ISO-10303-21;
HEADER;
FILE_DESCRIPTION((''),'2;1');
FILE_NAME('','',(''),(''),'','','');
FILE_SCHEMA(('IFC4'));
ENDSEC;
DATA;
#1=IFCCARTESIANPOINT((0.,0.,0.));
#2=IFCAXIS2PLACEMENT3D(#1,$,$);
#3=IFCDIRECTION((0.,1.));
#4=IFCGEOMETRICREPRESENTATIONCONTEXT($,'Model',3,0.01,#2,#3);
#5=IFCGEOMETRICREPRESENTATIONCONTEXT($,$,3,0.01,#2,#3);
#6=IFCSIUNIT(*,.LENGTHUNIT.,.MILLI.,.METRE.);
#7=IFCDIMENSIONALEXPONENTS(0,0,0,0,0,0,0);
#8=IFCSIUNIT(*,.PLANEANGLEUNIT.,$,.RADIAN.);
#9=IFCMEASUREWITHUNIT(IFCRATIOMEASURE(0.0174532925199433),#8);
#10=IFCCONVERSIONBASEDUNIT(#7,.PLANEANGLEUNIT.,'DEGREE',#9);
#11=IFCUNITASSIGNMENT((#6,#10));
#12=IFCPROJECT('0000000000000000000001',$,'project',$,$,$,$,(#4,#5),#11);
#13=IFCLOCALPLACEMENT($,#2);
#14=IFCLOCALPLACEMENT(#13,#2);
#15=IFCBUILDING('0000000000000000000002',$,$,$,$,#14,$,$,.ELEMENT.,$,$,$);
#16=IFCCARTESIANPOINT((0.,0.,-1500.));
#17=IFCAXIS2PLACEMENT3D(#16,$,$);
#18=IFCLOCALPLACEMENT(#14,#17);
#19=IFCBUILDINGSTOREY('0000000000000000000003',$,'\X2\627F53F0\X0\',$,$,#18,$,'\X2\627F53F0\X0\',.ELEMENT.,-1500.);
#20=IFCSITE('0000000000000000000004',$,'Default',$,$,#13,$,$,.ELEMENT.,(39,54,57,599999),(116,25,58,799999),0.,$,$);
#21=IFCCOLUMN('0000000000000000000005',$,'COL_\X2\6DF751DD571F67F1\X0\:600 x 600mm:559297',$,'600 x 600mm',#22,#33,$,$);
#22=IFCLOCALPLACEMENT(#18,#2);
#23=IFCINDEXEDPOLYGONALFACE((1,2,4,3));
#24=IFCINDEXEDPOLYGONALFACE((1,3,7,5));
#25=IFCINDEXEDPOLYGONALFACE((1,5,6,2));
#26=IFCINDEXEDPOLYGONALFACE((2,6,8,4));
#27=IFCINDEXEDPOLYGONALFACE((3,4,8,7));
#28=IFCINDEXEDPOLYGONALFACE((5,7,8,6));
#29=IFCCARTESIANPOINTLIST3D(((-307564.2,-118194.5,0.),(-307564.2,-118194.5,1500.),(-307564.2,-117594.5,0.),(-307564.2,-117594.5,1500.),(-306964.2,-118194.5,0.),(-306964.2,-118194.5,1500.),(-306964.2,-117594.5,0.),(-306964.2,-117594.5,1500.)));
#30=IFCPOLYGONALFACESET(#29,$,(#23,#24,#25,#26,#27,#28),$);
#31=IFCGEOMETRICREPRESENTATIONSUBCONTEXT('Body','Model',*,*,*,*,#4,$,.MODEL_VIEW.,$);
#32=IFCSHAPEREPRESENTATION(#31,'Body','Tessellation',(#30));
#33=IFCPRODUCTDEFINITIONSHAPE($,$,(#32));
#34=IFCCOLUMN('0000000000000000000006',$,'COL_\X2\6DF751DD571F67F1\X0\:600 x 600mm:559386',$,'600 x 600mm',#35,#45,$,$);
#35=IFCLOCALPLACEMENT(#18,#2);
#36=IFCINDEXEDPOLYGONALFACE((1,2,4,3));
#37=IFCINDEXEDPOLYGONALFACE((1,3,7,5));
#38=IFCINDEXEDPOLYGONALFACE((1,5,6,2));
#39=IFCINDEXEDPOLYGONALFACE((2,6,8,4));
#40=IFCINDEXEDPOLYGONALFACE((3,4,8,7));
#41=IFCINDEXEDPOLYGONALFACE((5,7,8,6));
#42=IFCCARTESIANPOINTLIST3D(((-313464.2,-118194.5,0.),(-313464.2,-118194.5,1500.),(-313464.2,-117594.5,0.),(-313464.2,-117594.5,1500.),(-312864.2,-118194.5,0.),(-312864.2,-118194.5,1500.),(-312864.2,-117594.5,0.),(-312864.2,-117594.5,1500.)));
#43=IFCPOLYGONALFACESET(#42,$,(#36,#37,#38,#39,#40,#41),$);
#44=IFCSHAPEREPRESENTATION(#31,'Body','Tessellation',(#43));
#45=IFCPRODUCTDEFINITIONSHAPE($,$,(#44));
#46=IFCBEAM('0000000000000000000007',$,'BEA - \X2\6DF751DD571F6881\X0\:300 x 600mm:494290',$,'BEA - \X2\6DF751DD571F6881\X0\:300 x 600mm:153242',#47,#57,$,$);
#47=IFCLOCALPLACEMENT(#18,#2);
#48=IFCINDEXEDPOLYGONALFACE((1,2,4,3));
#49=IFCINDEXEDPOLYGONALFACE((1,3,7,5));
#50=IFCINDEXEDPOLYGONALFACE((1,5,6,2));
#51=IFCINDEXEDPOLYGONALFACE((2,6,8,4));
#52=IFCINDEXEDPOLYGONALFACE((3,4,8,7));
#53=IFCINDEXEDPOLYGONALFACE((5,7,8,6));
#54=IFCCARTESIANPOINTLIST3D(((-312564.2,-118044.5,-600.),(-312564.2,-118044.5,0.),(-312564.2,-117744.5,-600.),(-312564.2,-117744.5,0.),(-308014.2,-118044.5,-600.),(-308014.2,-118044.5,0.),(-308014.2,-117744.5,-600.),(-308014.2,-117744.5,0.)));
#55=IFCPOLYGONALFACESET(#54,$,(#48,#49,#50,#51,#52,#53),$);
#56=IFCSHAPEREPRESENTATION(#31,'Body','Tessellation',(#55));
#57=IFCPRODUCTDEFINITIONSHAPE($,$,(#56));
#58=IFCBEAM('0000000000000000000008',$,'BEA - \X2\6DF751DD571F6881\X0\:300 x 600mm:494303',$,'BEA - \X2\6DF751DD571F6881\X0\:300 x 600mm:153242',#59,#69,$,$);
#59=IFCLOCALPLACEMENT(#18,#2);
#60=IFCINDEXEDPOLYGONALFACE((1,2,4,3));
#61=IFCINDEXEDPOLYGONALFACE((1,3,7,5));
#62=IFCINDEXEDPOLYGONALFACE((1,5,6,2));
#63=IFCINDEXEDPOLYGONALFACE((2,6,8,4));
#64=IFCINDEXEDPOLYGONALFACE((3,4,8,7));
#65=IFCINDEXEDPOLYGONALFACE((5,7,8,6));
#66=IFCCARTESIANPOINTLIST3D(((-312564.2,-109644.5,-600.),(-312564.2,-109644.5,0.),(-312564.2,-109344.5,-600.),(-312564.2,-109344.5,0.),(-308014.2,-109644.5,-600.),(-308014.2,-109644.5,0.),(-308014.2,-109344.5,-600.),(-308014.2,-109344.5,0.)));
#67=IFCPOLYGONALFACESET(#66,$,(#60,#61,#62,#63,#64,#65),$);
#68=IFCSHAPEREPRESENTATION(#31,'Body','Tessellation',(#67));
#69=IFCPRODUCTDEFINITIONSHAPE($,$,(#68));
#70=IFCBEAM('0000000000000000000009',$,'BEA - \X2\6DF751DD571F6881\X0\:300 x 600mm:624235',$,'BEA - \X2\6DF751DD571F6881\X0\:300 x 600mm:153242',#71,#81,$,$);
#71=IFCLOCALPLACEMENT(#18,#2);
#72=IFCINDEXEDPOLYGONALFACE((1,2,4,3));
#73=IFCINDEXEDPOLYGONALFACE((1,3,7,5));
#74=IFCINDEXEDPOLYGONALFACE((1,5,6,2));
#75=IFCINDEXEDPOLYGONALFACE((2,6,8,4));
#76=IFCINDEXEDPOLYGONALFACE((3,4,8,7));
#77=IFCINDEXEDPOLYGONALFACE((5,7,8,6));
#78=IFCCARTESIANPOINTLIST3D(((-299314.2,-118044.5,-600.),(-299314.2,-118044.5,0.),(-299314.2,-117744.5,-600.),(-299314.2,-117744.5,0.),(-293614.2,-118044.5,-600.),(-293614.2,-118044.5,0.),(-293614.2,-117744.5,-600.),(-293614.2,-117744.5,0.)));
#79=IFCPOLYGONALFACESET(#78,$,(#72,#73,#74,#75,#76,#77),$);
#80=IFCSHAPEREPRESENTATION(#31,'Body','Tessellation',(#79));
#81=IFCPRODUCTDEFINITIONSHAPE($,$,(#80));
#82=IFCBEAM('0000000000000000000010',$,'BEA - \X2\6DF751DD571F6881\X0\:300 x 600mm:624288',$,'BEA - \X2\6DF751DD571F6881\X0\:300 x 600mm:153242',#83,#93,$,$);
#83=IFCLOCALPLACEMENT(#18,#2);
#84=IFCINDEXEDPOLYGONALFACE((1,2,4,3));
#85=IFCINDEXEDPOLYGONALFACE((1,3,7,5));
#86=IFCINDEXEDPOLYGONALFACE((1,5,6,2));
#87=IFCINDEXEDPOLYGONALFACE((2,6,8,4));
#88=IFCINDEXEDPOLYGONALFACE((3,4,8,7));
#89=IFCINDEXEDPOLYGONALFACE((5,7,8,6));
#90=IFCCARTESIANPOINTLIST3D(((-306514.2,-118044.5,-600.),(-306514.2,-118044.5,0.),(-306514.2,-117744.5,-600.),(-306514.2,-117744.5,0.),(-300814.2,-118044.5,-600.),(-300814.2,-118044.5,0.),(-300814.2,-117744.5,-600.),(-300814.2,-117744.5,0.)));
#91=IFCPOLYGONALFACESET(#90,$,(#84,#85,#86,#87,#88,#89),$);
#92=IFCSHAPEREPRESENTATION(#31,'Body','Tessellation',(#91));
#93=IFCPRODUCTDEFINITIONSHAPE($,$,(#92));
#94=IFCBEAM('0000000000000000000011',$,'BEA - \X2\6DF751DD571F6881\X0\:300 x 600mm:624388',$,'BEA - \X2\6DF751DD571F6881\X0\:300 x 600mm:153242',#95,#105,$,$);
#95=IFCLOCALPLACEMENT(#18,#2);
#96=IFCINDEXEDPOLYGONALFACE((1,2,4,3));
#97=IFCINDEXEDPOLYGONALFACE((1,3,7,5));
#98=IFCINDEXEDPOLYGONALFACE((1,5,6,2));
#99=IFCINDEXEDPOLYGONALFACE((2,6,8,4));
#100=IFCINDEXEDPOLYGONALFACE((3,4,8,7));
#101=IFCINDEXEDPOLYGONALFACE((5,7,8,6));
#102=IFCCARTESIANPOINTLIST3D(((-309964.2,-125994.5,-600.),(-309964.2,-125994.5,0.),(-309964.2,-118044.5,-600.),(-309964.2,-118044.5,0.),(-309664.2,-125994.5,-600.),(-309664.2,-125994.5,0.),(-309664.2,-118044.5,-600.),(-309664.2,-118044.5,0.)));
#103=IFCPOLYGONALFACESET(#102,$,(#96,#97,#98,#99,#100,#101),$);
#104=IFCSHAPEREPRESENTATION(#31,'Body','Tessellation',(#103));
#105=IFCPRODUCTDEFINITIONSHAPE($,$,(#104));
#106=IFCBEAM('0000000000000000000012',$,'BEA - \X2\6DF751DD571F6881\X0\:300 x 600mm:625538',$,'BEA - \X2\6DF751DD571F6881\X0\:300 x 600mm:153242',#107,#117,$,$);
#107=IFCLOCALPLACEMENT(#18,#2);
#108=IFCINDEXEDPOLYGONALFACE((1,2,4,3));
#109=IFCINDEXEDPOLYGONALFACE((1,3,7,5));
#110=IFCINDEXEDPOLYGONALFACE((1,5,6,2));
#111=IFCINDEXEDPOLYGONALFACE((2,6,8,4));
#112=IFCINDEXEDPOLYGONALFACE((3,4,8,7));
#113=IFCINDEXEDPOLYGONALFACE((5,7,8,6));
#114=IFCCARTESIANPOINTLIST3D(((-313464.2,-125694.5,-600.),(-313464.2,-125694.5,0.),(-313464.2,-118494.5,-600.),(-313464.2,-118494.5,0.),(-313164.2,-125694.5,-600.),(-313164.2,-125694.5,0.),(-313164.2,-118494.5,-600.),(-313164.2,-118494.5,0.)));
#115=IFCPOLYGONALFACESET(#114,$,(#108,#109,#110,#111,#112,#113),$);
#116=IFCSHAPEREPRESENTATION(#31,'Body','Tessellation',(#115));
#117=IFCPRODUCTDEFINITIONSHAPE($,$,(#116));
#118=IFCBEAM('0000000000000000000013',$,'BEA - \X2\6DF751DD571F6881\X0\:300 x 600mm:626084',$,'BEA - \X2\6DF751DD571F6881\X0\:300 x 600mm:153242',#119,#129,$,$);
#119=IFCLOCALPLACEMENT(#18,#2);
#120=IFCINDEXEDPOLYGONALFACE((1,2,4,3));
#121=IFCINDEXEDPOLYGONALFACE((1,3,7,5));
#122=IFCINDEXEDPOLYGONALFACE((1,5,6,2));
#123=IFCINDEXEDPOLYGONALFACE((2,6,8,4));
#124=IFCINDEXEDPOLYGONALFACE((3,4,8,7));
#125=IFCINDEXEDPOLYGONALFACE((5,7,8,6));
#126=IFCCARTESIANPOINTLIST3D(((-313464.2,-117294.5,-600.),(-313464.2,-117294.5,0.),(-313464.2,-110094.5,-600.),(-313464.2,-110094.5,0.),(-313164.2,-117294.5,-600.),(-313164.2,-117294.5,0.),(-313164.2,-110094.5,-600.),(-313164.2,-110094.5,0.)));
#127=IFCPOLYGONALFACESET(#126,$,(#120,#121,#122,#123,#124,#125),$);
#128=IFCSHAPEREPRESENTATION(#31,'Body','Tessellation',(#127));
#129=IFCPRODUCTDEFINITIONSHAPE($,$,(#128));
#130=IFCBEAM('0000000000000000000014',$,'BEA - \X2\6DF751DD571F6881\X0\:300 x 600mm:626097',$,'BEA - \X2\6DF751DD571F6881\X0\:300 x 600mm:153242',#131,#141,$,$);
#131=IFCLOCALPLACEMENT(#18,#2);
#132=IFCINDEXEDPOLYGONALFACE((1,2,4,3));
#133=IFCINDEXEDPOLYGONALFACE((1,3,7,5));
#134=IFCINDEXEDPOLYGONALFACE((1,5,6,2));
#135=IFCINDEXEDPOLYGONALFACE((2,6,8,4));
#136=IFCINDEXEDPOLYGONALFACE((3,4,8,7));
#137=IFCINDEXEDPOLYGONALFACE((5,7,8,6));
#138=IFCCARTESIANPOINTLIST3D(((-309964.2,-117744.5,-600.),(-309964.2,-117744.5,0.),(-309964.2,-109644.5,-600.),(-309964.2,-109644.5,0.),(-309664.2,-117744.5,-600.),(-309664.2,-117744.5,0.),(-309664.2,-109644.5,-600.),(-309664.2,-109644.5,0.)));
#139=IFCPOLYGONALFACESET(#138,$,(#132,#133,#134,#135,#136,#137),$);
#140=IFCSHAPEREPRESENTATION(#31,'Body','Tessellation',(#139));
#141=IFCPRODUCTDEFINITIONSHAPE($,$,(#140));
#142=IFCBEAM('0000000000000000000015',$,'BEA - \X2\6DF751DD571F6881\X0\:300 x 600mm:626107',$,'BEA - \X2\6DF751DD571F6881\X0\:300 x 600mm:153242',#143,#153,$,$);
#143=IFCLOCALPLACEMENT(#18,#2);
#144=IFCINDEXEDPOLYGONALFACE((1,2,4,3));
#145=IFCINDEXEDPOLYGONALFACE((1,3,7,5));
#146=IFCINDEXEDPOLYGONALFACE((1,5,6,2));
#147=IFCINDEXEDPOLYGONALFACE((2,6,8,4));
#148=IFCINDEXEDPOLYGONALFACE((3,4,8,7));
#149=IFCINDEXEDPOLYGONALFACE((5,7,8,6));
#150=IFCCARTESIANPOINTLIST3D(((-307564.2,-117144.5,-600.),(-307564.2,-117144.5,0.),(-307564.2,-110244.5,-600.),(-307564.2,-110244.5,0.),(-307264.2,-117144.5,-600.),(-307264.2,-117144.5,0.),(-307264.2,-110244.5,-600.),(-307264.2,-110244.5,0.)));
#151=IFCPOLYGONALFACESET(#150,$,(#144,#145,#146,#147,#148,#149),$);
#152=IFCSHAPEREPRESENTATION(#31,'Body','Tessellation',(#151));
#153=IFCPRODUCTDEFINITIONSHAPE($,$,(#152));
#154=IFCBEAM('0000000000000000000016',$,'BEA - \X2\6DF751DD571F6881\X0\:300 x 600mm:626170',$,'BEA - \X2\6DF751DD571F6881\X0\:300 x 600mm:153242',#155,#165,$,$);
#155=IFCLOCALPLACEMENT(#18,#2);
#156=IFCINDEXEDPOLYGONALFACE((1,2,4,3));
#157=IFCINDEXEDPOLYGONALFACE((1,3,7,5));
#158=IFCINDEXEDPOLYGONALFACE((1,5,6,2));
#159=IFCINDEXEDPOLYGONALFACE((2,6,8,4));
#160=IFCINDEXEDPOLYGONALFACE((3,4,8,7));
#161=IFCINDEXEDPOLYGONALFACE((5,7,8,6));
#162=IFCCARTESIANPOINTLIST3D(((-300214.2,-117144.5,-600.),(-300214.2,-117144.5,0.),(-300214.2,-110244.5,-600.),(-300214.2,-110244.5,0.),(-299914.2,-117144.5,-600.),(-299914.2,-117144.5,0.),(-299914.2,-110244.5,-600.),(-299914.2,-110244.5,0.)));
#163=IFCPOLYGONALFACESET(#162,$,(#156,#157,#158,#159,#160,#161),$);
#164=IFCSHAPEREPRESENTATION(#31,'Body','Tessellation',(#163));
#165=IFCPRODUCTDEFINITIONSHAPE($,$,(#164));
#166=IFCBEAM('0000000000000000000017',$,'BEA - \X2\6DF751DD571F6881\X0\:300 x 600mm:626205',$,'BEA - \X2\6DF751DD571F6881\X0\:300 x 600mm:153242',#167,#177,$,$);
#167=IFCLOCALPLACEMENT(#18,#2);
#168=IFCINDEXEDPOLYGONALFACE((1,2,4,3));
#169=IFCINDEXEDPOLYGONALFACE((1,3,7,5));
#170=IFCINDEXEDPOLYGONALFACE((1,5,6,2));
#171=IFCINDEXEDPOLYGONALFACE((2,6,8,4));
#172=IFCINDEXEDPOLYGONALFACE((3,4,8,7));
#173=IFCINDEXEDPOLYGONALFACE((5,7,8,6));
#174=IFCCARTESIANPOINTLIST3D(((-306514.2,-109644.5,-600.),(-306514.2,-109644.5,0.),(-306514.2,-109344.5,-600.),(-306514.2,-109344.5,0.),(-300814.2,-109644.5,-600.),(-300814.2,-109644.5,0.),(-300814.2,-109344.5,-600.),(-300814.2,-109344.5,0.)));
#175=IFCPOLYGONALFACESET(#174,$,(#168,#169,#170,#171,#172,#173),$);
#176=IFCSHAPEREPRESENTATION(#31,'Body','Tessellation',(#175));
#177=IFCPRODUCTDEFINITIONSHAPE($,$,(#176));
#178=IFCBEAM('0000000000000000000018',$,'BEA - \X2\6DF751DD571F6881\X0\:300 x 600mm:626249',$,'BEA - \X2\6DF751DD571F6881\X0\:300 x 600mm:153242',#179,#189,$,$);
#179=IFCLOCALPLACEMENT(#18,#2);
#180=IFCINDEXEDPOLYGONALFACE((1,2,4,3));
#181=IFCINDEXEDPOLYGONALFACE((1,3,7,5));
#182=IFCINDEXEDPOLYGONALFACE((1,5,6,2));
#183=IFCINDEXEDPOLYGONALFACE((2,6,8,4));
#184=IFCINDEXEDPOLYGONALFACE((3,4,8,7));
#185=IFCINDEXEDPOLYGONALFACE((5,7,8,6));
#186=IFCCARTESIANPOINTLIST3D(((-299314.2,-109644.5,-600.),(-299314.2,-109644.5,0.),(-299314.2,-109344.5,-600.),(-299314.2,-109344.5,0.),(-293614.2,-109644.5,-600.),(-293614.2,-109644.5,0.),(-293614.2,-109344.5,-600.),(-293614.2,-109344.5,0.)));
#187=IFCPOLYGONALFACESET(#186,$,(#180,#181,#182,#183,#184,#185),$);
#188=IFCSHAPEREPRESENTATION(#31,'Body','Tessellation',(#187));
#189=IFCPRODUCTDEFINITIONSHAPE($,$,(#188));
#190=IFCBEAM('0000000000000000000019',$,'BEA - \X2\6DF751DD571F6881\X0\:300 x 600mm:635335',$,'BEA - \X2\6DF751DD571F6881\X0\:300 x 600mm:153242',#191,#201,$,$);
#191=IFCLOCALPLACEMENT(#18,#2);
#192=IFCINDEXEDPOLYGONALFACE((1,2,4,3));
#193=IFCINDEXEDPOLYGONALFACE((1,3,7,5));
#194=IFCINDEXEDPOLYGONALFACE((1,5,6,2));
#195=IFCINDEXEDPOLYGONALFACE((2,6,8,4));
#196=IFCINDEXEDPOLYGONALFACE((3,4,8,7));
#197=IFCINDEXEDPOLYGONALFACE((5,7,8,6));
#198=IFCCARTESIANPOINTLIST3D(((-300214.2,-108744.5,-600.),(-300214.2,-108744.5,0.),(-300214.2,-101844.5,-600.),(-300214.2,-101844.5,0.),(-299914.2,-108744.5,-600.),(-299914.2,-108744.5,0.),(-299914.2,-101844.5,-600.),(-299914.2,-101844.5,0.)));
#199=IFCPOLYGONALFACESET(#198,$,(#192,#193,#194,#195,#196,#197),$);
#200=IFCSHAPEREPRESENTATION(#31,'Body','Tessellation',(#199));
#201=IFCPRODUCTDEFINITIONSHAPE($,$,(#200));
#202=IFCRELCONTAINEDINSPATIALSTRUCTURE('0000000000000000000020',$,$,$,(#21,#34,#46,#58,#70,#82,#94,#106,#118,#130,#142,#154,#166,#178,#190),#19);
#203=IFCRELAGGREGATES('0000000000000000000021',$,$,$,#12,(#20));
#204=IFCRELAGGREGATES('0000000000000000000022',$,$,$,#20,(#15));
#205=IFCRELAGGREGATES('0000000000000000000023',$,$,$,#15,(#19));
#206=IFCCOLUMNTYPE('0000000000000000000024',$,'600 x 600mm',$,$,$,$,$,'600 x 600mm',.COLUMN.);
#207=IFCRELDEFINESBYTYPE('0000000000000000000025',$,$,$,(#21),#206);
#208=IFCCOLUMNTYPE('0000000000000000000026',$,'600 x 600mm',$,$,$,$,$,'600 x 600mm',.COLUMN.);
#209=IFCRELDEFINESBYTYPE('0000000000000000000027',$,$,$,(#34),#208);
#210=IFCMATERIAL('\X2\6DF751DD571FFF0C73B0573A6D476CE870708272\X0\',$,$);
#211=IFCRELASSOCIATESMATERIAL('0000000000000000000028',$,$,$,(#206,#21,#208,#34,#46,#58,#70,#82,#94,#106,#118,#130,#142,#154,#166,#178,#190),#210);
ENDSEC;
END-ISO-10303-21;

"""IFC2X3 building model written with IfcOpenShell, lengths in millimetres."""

from ifc_helpers import new_model, entity, si_unit, converted_unit, direction, frame, frame_2d, origin, origin_2d_with_axis, place, context, subcontext, project, spatial, rectangle, extrude, source, transform, mapped, material, type_object, type_shapes, element, save


model = new_model("IFC2X3")

# Units and contexts
model_context = context("Model", 3, precision=0.01, world=origin(), true_north=direction((0.0, 1.0)))
context_of_model = context(None, 3, precision=0.01, world=origin(), true_north=direction((0.0, 1.0)))
body_context = subcontext(model_context, "Body", "Model", "MODEL_VIEW")
ifc_project = project(units=[si_unit("LENGTHUNIT", "METRE", prefix="MILLI"), converted_unit("PLANEANGLEUNIT", "DEGREE", entity("IfcRatioMeasure", 0.0174532925199433), si_unit("PLANEANGLEUNIT", "RADIAN"), dimensions=[0, 0, 0, 0, 0, 0, 0])], contexts=[model_context, context_of_model])

# Site, building, storey
site_placement = place(None, origin())
site = spatial("IfcSite", under=ifc_project, at=site_placement, Name="Default", CompositionType="ELEMENT", RefLatitude=(39, 54, 57, 599999), RefLongitude=(116, 25, 58, 799999), RefElevation=0.0)
building_placement = place(site_placement, origin())
building = spatial("IfcBuilding", under=site, at=building_placement, CompositionType="ELEMENT")
storey_placement = place(building_placement, frame((0.0, 0.0, -1500.0)))
storey = spatial("IfcBuildingStorey", under=building, at=storey_placement, Name="承台", LongName="承台", CompositionType="ELEMENT", Elevation=-1500.0)

# Columns
ifc_material_1 = material(Name="混凝土，现场浇注灰色")
column_type_1 = type_object("IfcColumnType", Name="600 x 600mm", ElementType="600 x 600mm", PredefinedType="COLUMN", material=ifc_material_1)
shared_shape_1 = source(origin(), body_context, "Body", "SweptSolid", [
    extrude(rectangle(XDim=600.0, YDim=600.0, at=origin_2d_with_axis()), frame((300.0, 300.0, 0.0), z_axis=(0.0, 0.0, 1.0), x_axis=(-1.0, 0.0, 0.0)), (0.0, 0.0, 1.0), 1500.0),
])
type_shapes(column_type_1, [shared_shape_1])
column_1_placement = place(storey_placement, frame((-307564.2, -118194.5, 0.0)))
element("IfcColumn", 1, at=column_1_placement, inside=storey, type_object=column_type_1, material=ifc_material_1, Name="COL_混凝土柱:600 x 600mm:559297", ObjectType="600 x 600mm", context=body_context, shape_type="MappedRepresentation", body=[
    mapped(shared_shape_1, transform((0.0, 0.0, 0.0), scale=1.0)),
])
column_type_2 = type_object("IfcColumnType", Name="600 x 600mm", ElementType="600 x 600mm", PredefinedType="COLUMN", material=ifc_material_1)
shared_shape_2 = source(origin(), body_context, "Body", "SweptSolid", [
    extrude(rectangle(XDim=600.0, YDim=600.0, at=origin_2d_with_axis()), frame((300.0, 300.0, 0.0), z_axis=(0.0, 0.0, 1.0), x_axis=(-1.0, 0.0, 0.0)), (0.0, 0.0, 1.0), 1500.0),
])
type_shapes(column_type_2, [shared_shape_2])
column_2_placement = place(storey_placement, frame((-313464.2, -118194.5, 0.0)))
element("IfcColumn", 2, at=column_2_placement, inside=storey, type_object=column_type_2, material=ifc_material_1, Name="COL_混凝土柱:600 x 600mm:559386", ObjectType="600 x 600mm", context=body_context, shape_type="MappedRepresentation", body=[
    mapped(shared_shape_2, transform((0.0, 0.0, 0.0), scale=1.0)),
])

# Beams
beam_1_placement = place(storey_placement, frame((-312564.2, -117894.5, 0.0)))
element("IfcBeam", 3, at=beam_1_placement, inside=storey, material=ifc_material_1, Name="BEA - 混凝土梁:300 x 600mm:494290", ObjectType="BEA - 混凝土梁:300 x 600mm:153242", context=body_context, shape_type="SweptSolid", body=[
    extrude(rectangle(XDim=600.0, YDim=300.0, at=frame_2d((0.0, 0.0), x_axis=(1.0, 0.0))), frame((0.0, 0.0, -300.0), z_axis=(1.0, 0.0, 0.0), x_axis=(0.0, 0.0, -1.0)), (0.0, 0.0, 1.0), 4550.0),
])
beam_2_placement = place(storey_placement, frame((-312564.2, -109494.5, 0.0)))
element("IfcBeam", 4, at=beam_2_placement, inside=storey, material=ifc_material_1, Name="BEA - 混凝土梁:300 x 600mm:494303", ObjectType="BEA - 混凝土梁:300 x 600mm:153242", context=body_context, shape_type="SweptSolid", body=[
    extrude(rectangle(XDim=600.0, YDim=300.0, at=frame_2d((0.0, 0.0), x_axis=(1.0, 0.0))), frame((0.0, 0.0, -300.0), z_axis=(1.0, 0.0, 0.0), x_axis=(0.0, 0.0, -1.0)), (0.0, 0.0, 1.0), 4550.0),
])
for number, where, z_axis, x_axis, name in (
    (5, (-293614.2, -117894.5, 0.0), (0.0, 0.0, 1.0), (-1.0, 0.0, 0.0), "BEA - 混凝土梁:300 x 600mm:624235"),
    (6, (-300814.2, -117894.5, 0.0), (0.0, 0.0, 1.0), (-1.0, 0.0, 0.0), "BEA - 混凝土梁:300 x 600mm:624288"),
):
    element("IfcBeam", number, at=place(storey_placement, frame(where, z_axis=z_axis, x_axis=x_axis)), inside=storey, material=ifc_material_1, Name=name, ObjectType="BEA - 混凝土梁:300 x 600mm:153242", context=body_context, shape_type="SweptSolid", body=[
        extrude(rectangle(XDim=600.0, YDim=300.0, at=frame_2d((0.0, 0.0), x_axis=(1.0, 0.0))), frame((0.0, 0.0, -300.0), z_axis=(1.0, 0.0, 0.0), x_axis=(0.0, 0.0, -1.0)), (0.0, 0.0, 1.0), 5700.0),
    ])
beam_3_placement = place(storey_placement, frame((-309814.2, -118044.5, 0.0), z_axis=(0.0, 0.0, 1.0), x_axis=(0.0, -1.0, 0.0)))
element("IfcBeam", 7, at=beam_3_placement, inside=storey, material=ifc_material_1, Name="BEA - 混凝土梁:300 x 600mm:624388", ObjectType="BEA - 混凝土梁:300 x 600mm:153242", context=body_context, shape_type="SweptSolid", body=[
    extrude(rectangle(XDim=600.0, YDim=300.0, at=origin_2d_with_axis()), frame((0.0, 0.0, -300.0), z_axis=(1.0, 0.0, 0.0), x_axis=(0.0, 0.0, -1.0)), (0.0, 0.0, 1.0), 7950.0),
])
for number, where, z_axis, x_axis, name in (
    (8, (-313314.2, -118494.5, 0.0), (0.0, 0.0, 1.0), (0.0, -1.0, 0.0), "BEA - 混凝土梁:300 x 600mm:625538"),
    (9, (-313314.2, -110094.5, 0.0), (0.0, 0.0, 1.0), (0.0, -1.0, 0.0), "BEA - 混凝土梁:300 x 600mm:626084"),
):
    element("IfcBeam", number, at=place(storey_placement, frame(where, z_axis=z_axis, x_axis=x_axis)), inside=storey, material=ifc_material_1, Name=name, ObjectType="BEA - 混凝土梁:300 x 600mm:153242", context=body_context, shape_type="SweptSolid", body=[
        extrude(rectangle(XDim=600.0, YDim=300.0, at=origin_2d_with_axis()), frame((0.0, 0.0, -300.0), z_axis=(1.0, 0.0, 0.0), x_axis=(0.0, 0.0, -1.0)), (0.0, 0.0, 1.0), 7200.0),
    ])
beam_4_placement = place(storey_placement, frame((-309814.2, -109644.5, 0.0), z_axis=(0.0, 0.0, 1.0), x_axis=(0.0, -1.0, 0.0)))
element("IfcBeam", 10, at=beam_4_placement, inside=storey, material=ifc_material_1, Name="BEA - 混凝土梁:300 x 600mm:626097", ObjectType="BEA - 混凝土梁:300 x 600mm:153242", context=body_context, shape_type="SweptSolid", body=[
    extrude(rectangle(XDim=600.0, YDim=300.0, at=origin_2d_with_axis()), frame((0.0, 0.0, -300.0), z_axis=(1.0, 0.0, 0.0), x_axis=(0.0, 0.0, -1.0)), (0.0, 0.0, 1.0), 8100.0),
])
for number, where, z_axis, x_axis, name in (
    (11, (-307414.2, -110244.5, 0.0), (0.0, 0.0, 1.0), (0.0, -1.0, 0.0), "BEA - 混凝土梁:300 x 600mm:626107"),
    (12, (-300064.2, -110244.5, 0.0), (0.0, 0.0, 1.0), (0.0, -1.0, 0.0), "BEA - 混凝土梁:300 x 600mm:626170"),
):
    element("IfcBeam", number, at=place(storey_placement, frame(where, z_axis=z_axis, x_axis=x_axis)), inside=storey, material=ifc_material_1, Name=name, ObjectType="BEA - 混凝土梁:300 x 600mm:153242", context=body_context, shape_type="SweptSolid", body=[
        extrude(rectangle(XDim=600.0, YDim=300.0, at=origin_2d_with_axis()), frame((0.0, 0.0, -300.0), z_axis=(1.0, 0.0, 0.0), x_axis=(0.0, 0.0, -1.0)), (0.0, 0.0, 1.0), 6900.0),
    ])
for number, where, z_axis, x_axis, name in (
    (13, (-300814.2, -109494.5, 0.0), (0.0, 0.0, 1.0), (-1.0, 0.0, 0.0), "BEA - 混凝土梁:300 x 600mm:626205"),
    (14, (-293614.2, -109494.5, 0.0), (0.0, 0.0, 1.0), (-1.0, 0.0, 0.0), "BEA - 混凝土梁:300 x 600mm:626249"),
):
    element("IfcBeam", number, at=place(storey_placement, frame(where, z_axis=z_axis, x_axis=x_axis)), inside=storey, material=ifc_material_1, Name=name, ObjectType="BEA - 混凝土梁:300 x 600mm:153242", context=body_context, shape_type="SweptSolid", body=[
        extrude(rectangle(XDim=600.0, YDim=300.0, at=frame_2d((0.0, 0.0), x_axis=(1.0, 0.0))), frame((0.0, 0.0, -300.0), z_axis=(1.0, 0.0, 0.0), x_axis=(0.0, 0.0, -1.0)), (0.0, 0.0, 1.0), 5700.0),
    ])
for number, where, z_axis, x_axis, name in (
    (15, (-300064.2, -101844.5, 0.0), (0.0, 0.0, 1.0), (0.0, -1.0, 0.0), "BEA - 混凝土梁:300 x 600mm:635335"),
):
    element("IfcBeam", number, at=place(storey_placement, frame(where, z_axis=z_axis, x_axis=x_axis)), inside=storey, material=ifc_material_1, Name=name, ObjectType="BEA - 混凝土梁:300 x 600mm:153242", context=body_context, shape_type="SweptSolid", body=[
        extrude(rectangle(XDim=600.0, YDim=300.0, at=origin_2d_with_axis()), frame((0.0, 0.0, -300.0), z_axis=(1.0, 0.0, 0.0), x_axis=(0.0, 0.0, -1.0)), (0.0, 0.0, 1.0), 6900.0),
    ])

save(model, "model.ifc")
